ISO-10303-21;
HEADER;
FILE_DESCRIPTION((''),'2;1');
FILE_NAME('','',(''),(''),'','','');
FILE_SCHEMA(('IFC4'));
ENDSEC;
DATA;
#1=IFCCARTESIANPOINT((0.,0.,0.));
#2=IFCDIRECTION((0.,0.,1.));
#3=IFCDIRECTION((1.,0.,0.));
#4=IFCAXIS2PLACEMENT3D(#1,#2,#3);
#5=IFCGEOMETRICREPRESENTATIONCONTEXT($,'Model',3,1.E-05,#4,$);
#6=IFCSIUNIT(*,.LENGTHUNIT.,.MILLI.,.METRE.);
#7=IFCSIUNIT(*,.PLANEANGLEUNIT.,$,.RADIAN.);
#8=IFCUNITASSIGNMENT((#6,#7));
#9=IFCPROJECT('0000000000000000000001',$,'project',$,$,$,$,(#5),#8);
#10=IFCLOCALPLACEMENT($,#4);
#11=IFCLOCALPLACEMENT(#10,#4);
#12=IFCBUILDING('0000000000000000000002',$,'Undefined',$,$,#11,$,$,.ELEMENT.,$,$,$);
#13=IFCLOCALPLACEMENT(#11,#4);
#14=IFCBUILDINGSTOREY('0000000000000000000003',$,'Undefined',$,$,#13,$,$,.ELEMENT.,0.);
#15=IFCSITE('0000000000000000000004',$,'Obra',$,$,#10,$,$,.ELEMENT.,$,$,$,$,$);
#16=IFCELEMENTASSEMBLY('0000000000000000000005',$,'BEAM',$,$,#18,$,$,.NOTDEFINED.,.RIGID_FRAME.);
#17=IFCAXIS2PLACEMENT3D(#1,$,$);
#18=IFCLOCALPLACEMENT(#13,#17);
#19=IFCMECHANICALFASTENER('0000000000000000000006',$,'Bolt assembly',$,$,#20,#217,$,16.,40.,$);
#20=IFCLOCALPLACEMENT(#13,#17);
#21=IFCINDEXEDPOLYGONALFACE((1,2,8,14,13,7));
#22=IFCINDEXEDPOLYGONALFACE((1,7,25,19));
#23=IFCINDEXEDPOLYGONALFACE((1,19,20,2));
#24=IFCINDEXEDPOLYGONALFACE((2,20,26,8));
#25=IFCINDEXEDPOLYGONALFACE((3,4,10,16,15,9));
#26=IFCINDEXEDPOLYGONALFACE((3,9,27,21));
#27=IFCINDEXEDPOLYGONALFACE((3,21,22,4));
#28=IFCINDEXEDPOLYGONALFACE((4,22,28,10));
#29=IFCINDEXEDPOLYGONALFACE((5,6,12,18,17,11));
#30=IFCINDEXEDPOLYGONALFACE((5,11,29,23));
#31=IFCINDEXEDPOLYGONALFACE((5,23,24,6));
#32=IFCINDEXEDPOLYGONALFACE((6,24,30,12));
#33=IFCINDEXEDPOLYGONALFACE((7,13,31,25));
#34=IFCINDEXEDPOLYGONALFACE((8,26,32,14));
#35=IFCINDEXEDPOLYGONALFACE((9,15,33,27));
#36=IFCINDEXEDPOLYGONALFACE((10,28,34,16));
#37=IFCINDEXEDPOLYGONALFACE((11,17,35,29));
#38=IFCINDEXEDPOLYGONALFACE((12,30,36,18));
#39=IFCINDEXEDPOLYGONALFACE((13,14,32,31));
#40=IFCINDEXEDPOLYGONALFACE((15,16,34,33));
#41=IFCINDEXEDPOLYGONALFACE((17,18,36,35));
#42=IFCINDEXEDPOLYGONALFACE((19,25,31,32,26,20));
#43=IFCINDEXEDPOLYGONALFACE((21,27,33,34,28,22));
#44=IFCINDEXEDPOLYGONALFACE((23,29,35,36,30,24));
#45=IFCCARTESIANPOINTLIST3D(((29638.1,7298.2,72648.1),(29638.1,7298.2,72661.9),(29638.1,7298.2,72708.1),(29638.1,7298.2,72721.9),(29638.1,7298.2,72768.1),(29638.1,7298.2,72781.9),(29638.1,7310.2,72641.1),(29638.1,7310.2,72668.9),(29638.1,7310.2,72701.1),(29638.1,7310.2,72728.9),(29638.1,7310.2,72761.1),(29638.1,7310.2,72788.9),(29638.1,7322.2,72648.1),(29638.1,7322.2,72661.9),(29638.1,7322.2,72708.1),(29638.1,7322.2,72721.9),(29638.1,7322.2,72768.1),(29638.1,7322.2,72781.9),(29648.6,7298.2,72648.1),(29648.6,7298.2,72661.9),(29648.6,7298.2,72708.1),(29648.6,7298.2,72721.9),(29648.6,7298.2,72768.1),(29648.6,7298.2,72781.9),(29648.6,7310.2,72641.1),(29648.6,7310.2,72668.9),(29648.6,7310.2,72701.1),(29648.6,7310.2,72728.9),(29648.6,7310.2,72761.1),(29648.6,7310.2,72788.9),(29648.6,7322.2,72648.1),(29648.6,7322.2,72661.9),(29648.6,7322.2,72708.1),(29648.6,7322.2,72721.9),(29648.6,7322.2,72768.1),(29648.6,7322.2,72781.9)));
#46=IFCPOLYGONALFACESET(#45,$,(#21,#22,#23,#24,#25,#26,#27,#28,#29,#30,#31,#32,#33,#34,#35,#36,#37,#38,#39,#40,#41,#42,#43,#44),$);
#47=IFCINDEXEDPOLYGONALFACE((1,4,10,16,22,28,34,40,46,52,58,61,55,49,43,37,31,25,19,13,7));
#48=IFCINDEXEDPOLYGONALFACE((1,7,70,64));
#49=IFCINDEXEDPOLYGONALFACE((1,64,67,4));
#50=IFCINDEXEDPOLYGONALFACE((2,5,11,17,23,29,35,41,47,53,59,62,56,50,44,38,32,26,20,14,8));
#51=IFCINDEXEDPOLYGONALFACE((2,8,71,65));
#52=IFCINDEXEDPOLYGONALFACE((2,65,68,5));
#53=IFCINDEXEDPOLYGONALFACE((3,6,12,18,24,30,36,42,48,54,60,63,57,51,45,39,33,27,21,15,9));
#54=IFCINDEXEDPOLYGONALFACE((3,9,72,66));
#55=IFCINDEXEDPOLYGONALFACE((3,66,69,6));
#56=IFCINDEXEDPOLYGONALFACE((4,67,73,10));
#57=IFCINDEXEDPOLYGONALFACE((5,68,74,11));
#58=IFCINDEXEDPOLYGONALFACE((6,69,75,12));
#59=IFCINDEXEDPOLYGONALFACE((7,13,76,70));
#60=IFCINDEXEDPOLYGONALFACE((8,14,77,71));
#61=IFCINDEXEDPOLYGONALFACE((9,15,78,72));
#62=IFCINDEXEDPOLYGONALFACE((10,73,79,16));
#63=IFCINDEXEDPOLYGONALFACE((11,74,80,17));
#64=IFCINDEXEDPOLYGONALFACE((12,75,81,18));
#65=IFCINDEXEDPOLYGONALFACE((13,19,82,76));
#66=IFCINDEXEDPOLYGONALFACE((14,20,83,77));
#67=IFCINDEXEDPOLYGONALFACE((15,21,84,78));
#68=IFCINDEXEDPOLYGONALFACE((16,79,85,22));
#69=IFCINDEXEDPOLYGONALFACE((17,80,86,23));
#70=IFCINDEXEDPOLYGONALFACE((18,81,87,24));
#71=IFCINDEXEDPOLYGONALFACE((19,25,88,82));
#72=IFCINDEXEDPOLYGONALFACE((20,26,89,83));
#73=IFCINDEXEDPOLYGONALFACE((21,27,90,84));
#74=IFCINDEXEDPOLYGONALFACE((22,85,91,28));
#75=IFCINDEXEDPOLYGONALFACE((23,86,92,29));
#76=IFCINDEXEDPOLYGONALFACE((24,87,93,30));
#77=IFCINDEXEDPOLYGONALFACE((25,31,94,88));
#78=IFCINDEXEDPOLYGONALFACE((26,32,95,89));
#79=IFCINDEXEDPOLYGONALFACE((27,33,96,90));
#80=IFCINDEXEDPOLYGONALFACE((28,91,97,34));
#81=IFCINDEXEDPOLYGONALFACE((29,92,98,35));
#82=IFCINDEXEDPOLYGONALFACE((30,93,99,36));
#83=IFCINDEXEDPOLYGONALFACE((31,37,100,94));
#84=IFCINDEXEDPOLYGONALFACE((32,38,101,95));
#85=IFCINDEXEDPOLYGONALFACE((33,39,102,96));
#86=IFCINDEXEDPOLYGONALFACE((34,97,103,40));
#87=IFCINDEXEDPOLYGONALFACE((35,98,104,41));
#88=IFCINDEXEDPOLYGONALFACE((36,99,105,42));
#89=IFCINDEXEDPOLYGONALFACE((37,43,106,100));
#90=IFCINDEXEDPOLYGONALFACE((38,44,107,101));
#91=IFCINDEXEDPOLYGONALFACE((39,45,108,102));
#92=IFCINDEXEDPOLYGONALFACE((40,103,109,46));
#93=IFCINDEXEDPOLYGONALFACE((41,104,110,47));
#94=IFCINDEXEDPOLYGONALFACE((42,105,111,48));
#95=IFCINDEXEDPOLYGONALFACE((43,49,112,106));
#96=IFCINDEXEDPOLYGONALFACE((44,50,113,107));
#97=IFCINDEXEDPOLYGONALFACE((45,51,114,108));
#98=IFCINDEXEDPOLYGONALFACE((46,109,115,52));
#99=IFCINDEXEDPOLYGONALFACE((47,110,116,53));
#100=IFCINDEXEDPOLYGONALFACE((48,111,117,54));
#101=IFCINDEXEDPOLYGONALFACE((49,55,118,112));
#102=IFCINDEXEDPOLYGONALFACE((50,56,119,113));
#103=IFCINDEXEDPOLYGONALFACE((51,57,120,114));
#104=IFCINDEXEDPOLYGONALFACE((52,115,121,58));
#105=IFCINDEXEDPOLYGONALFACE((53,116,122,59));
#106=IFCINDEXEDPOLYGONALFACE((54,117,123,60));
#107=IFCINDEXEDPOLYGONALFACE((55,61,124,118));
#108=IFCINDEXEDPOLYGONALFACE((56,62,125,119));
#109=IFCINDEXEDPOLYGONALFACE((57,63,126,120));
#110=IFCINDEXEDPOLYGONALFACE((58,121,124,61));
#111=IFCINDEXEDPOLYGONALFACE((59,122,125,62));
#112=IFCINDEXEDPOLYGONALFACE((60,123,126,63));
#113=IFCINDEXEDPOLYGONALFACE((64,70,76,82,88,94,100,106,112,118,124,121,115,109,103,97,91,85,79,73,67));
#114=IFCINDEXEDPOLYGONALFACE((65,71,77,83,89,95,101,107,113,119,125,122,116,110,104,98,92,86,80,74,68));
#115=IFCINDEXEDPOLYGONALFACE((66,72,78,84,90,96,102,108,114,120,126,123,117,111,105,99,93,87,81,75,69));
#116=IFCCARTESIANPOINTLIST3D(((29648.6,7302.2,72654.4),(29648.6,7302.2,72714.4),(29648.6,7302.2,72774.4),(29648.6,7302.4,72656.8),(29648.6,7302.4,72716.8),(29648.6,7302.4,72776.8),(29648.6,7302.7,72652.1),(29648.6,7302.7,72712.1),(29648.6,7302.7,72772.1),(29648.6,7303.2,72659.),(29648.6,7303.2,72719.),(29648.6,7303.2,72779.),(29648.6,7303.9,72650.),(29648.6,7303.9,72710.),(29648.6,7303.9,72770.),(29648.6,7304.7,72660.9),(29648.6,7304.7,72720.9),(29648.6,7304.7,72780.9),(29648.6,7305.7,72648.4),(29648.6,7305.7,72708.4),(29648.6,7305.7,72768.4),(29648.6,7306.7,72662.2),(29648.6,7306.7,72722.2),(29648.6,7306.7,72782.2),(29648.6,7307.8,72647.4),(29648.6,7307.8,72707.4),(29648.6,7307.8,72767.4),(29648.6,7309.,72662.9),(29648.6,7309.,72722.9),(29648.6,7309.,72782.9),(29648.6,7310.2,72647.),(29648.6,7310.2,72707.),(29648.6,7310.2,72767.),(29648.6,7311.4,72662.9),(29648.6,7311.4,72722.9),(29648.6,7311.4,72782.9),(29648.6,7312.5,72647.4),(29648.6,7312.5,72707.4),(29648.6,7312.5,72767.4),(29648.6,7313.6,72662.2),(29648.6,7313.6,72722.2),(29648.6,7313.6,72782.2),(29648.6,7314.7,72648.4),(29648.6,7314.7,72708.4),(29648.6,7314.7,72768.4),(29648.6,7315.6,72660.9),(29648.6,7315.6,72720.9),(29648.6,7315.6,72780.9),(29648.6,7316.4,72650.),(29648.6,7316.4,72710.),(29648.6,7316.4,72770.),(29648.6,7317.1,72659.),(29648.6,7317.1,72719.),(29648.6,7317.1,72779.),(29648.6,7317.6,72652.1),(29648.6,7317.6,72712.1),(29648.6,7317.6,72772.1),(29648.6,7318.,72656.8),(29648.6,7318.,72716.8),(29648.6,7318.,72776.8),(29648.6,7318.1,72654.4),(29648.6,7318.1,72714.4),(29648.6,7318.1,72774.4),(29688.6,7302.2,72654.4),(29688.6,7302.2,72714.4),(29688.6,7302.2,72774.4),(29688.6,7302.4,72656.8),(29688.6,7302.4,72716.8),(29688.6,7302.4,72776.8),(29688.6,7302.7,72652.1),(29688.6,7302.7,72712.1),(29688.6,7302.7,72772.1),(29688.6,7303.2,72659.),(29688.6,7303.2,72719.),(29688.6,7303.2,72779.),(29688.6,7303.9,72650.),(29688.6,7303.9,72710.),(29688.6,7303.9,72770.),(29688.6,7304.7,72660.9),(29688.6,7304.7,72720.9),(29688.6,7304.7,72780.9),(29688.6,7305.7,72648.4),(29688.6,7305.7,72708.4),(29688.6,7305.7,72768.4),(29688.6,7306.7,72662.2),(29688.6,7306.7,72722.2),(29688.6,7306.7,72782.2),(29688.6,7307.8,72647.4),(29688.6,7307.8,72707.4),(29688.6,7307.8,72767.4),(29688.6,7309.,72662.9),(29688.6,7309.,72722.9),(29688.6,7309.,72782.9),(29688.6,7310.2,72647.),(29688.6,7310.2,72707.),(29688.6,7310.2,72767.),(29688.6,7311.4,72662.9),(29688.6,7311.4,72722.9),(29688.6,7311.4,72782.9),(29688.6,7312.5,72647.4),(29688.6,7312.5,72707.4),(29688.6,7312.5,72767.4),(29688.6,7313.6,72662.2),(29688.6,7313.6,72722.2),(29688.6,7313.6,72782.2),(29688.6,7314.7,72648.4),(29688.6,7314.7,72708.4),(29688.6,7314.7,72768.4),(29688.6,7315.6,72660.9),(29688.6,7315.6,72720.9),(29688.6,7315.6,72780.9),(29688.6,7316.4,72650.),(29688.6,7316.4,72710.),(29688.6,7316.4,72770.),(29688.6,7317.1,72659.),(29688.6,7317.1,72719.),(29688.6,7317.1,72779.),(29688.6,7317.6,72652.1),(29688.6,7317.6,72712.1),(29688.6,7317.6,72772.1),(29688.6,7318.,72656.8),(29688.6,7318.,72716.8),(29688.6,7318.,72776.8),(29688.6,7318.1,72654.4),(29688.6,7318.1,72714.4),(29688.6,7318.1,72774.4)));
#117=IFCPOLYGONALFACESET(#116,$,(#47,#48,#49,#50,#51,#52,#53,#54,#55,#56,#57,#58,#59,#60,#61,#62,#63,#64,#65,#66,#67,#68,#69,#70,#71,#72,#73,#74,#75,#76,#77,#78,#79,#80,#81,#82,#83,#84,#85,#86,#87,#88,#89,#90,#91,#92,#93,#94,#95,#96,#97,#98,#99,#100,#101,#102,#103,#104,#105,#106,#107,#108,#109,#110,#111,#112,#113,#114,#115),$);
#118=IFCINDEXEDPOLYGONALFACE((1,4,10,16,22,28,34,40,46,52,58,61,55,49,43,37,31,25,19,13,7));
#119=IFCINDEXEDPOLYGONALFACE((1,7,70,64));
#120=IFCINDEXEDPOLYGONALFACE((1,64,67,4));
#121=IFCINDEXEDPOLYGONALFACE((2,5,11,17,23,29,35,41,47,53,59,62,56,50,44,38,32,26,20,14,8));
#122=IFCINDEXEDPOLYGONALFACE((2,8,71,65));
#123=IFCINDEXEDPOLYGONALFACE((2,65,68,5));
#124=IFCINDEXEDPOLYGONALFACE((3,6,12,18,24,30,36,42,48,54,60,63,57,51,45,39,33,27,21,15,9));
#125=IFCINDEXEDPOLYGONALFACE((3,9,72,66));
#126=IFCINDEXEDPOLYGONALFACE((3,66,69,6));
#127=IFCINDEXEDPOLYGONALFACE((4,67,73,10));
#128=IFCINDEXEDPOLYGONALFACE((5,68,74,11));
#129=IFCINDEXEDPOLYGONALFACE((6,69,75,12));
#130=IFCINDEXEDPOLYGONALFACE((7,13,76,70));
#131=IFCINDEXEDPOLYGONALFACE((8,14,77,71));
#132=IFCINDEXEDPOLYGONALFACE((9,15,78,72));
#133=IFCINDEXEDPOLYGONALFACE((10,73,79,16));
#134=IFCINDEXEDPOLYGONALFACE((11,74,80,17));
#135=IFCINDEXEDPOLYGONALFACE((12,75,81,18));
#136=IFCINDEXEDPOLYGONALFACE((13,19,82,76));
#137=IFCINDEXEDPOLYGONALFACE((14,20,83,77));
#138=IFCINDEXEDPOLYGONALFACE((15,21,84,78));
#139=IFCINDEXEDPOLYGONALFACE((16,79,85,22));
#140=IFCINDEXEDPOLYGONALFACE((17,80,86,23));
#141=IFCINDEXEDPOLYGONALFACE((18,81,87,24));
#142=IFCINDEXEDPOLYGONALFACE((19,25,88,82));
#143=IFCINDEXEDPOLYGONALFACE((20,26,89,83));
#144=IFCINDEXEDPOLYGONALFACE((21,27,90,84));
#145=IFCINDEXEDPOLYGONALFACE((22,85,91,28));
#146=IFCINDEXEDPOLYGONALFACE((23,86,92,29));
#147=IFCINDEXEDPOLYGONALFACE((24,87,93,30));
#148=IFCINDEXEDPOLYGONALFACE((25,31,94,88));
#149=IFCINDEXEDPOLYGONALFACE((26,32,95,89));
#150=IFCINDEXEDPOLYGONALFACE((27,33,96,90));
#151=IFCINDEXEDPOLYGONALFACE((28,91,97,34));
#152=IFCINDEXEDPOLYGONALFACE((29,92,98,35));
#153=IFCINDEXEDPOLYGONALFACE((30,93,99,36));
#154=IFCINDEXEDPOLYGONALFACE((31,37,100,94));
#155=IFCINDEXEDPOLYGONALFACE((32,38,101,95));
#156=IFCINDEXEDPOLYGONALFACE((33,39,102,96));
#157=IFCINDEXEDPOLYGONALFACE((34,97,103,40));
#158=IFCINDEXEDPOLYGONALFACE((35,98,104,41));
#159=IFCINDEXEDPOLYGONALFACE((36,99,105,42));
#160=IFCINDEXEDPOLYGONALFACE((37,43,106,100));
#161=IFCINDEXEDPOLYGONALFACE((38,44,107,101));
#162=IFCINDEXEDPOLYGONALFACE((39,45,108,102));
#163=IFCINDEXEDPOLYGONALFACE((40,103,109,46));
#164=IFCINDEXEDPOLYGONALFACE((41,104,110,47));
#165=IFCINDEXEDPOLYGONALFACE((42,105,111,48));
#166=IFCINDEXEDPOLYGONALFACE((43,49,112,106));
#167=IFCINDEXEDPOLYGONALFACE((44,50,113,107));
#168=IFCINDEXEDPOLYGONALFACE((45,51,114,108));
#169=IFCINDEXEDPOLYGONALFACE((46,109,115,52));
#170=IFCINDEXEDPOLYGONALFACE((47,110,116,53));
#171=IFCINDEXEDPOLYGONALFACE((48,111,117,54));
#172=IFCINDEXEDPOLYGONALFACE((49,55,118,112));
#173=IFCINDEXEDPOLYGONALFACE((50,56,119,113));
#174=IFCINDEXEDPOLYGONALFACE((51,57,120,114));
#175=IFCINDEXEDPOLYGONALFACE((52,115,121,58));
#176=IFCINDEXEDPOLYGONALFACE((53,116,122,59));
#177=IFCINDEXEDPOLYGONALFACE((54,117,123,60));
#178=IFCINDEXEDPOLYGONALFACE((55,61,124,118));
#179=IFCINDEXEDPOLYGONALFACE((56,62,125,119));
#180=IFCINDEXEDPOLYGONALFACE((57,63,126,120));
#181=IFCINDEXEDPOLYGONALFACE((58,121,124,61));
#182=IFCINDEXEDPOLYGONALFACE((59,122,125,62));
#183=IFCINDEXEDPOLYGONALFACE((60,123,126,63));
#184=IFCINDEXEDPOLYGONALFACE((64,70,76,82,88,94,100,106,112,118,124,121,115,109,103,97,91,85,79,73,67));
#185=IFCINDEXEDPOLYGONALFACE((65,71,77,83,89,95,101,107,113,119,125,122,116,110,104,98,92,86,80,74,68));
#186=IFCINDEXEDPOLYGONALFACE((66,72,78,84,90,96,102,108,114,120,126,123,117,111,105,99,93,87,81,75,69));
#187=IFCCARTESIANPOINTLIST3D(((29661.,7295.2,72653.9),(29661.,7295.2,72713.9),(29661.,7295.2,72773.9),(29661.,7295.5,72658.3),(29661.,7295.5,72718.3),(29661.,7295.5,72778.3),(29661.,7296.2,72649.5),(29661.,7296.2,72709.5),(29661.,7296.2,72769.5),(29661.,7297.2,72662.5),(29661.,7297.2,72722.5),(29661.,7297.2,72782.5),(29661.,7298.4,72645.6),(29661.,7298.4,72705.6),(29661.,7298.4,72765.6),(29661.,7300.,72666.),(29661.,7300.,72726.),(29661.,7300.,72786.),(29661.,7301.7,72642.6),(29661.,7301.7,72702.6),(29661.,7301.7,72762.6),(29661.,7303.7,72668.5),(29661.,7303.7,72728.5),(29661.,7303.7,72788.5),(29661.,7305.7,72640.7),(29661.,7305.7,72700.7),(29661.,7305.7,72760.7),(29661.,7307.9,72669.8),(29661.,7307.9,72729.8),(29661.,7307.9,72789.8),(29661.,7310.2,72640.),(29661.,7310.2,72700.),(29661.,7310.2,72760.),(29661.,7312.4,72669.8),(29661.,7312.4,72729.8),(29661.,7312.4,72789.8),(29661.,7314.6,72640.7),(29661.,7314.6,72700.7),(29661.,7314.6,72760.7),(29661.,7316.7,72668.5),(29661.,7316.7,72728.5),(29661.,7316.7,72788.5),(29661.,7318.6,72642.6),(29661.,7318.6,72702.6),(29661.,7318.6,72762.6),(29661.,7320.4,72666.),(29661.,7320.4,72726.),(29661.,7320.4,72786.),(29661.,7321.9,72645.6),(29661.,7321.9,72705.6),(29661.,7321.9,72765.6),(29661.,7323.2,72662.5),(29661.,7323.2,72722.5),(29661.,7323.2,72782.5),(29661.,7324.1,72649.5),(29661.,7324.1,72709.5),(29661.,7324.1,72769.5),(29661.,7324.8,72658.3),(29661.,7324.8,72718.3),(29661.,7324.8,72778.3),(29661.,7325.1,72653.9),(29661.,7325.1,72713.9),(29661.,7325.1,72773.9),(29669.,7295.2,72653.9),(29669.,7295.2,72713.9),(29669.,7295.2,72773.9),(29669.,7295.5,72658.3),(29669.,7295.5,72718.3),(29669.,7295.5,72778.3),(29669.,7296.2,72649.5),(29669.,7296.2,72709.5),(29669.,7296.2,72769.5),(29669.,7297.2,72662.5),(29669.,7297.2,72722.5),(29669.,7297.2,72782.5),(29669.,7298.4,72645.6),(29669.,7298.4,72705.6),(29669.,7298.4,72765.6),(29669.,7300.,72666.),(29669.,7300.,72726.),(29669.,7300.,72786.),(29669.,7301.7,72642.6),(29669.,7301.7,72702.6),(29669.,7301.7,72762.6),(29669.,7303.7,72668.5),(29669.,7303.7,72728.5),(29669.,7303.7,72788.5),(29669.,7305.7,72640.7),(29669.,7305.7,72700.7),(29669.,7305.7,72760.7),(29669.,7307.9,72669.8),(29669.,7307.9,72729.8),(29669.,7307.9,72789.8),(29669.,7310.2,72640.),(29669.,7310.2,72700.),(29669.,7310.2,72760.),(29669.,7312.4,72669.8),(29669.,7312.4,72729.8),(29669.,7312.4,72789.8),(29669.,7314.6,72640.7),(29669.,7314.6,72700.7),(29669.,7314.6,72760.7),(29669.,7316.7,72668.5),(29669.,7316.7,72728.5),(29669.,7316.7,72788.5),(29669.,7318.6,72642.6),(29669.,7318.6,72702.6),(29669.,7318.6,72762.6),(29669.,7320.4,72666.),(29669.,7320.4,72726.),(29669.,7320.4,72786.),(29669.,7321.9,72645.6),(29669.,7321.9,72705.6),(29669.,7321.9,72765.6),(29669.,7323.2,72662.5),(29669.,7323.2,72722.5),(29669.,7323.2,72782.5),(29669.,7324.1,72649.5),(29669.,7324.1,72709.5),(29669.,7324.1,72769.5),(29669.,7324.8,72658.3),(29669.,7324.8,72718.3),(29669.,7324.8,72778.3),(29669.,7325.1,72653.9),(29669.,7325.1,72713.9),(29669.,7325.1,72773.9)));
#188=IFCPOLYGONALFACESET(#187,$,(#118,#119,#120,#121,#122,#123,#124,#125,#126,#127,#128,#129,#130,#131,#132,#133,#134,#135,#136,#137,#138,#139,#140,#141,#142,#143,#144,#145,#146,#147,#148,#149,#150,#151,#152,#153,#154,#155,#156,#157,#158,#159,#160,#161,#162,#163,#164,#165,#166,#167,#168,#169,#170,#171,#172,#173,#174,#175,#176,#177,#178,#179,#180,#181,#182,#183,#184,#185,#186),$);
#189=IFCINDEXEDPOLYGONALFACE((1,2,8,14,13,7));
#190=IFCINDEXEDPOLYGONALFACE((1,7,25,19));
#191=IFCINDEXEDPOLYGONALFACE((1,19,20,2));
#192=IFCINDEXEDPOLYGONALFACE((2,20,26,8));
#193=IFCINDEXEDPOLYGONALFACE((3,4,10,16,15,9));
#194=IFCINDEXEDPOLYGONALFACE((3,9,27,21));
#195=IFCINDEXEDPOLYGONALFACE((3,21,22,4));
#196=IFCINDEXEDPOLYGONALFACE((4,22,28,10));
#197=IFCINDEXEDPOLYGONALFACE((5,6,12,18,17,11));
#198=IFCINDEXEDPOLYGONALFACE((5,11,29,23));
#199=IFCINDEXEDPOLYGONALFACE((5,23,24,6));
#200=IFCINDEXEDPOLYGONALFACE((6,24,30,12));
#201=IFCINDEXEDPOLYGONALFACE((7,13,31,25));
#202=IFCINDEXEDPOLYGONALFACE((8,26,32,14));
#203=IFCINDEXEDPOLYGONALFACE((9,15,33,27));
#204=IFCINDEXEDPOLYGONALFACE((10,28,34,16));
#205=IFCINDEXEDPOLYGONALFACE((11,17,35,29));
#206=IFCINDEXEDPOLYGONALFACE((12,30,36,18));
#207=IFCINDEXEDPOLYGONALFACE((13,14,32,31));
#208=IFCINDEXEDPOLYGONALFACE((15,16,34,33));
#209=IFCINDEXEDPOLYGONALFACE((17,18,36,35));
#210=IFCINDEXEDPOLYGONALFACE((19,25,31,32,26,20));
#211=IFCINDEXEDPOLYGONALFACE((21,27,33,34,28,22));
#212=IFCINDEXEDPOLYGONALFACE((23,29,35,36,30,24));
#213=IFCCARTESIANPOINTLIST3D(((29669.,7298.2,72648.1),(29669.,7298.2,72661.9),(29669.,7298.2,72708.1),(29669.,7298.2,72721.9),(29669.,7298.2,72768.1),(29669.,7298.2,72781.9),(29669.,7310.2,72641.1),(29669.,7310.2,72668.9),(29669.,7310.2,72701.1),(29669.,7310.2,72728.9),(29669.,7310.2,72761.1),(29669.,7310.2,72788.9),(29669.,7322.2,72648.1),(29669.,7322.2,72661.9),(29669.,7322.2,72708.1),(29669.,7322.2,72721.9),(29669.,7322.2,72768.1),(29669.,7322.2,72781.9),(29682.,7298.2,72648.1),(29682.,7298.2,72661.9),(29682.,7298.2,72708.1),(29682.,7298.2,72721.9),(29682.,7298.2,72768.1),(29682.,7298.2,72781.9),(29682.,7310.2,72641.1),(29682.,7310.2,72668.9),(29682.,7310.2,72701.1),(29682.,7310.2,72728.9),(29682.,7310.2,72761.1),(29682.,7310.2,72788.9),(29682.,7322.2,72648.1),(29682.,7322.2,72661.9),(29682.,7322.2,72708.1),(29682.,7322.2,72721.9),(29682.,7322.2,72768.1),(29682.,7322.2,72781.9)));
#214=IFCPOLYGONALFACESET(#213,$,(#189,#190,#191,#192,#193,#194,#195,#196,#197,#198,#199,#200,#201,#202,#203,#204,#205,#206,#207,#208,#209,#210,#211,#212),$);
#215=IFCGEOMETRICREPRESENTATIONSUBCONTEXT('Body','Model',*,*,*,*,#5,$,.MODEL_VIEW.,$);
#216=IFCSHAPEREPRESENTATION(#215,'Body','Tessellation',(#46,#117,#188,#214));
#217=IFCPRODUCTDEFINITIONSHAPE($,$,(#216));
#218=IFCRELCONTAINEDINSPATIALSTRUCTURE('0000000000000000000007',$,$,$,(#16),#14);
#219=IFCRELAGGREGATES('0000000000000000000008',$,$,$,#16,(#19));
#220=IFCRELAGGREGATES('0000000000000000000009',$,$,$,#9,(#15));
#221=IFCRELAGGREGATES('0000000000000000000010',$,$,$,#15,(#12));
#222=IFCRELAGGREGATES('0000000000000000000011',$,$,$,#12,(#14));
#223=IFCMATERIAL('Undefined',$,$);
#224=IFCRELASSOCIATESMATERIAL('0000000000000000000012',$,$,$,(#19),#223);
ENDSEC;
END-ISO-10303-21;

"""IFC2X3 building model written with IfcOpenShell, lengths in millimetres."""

from ifc_helpers import new_model, si_unit, frame, origin_with_axes, origin_2d_with_axis, place, context, subcontext, project, spatial, polyline, circle, outline, extrude, source, transform, mapped, material, element, aggregate, save


model = new_model("IFC2X3")

# Units and contexts
model_context = context("Model", 3, precision=1e-05, world=origin_with_axes())
body_context = subcontext(model_context, "Body", "Model", "MODEL_VIEW")
ifc_project = project(units=[si_unit("LENGTHUNIT", "METRE", prefix="MILLI"), si_unit("PLANEANGLEUNIT", "RADIAN")], contexts=[model_context])

# Site, building, storey
site_placement = place(None, origin_with_axes())
site = spatial("IfcSite", under=ifc_project, at=site_placement, Name="Obra", CompositionType="ELEMENT")
building_placement = place(site_placement, origin_with_axes())
building = spatial("IfcBuilding", under=site, at=building_placement, Name="Undefined", CompositionType="ELEMENT")
storey_placement = place(building_placement, origin_with_axes())
storey = spatial("IfcBuildingStorey", under=building, at=storey_placement, Name="Undefined", CompositionType="ELEMENT", Elevation=0.0)

# Shared definitions
ifc_material = material(Name="Undefined")

# Element assembly, mechanical fastener
assembly_1_placement = place(storey_placement, origin_with_axes())
assembly_1 = element("IfcElementAssembly", 1, at=assembly_1_placement, inside=storey, Name="BEAM", AssemblyPlace="NOTDEFINED", PredefinedType="RIGID_FRAME")
shared_shape_1 = source(origin_with_axes(), body_context, "Body", "SweptSolid", [
    extrude(outline(polyline([(13.9, 0.0), (6.9, 12.0), (-6.9, 12.0), (-13.9, 0.0), (-6.9, -12.0), (6.9, -12.0), (13.9, 0.0)])), frame((0.0, -19.7, 0.0), z_axis=(0.0, 1.0, 0.0), x_axis=(1.0, 0.0, 0.0)), (0.0, 0.0, 1.0), 10.6),
    extrude(circle(Radius=8.0, at=origin_2d_with_axis()), frame((0.0, -9.1, 0.0), z_axis=(0.0, 1.0, 0.0), x_axis=(1.0, 0.0, 0.0)), (0.0, 0.0, 1.0), 40.0),
    extrude(circle(Radius=15.0, at=origin_2d_with_axis()), frame((0.0, 3.3, 0.0), z_axis=(0.0, 1.0, 0.0), x_axis=(1.0, 0.0, 0.0)), (0.0, 0.0, 1.0), 8.0),
    extrude(outline(polyline([(13.9, 0.0), (6.9, 12.0), (-6.9, 12.0), (-13.9, 0.0), (-6.9, -12.0), (6.9, -12.0), (13.9, 0.0)])), frame((0.0, 11.3, 0.0), z_axis=(0.0, 1.0, 0.0), x_axis=(1.0, 0.0, 0.0)), (0.0, 0.0, 1.0), 13.0),
])
mechanical_fastener_1_placement = place(assembly_1_placement, frame((29657.7, 7360.2, 72835.0), z_axis=(0.000005, -1.0, 0.0), x_axis=(0.0, 0.0, -1.0)))
mechanical_fastener_1 = element("IfcMechanicalFastener", 2, at=mechanical_fastener_1_placement, material=ifc_material, Name="Bolt assembly", NominalDiameter=16.0, NominalLength=40.0, context=body_context, shape_type="MappedRepresentation", body=[
    mapped(shared_shape_1, transform((60.0, 0.0, 50.0))),
    mapped(shared_shape_1, transform((120.0, 0.0, 50.0))),
    mapped(shared_shape_1, transform((180.0, 0.0, 50.0))),
])
aggregate(assembly_1, [mechanical_fastener_1])

save(model, "model.ifc")
